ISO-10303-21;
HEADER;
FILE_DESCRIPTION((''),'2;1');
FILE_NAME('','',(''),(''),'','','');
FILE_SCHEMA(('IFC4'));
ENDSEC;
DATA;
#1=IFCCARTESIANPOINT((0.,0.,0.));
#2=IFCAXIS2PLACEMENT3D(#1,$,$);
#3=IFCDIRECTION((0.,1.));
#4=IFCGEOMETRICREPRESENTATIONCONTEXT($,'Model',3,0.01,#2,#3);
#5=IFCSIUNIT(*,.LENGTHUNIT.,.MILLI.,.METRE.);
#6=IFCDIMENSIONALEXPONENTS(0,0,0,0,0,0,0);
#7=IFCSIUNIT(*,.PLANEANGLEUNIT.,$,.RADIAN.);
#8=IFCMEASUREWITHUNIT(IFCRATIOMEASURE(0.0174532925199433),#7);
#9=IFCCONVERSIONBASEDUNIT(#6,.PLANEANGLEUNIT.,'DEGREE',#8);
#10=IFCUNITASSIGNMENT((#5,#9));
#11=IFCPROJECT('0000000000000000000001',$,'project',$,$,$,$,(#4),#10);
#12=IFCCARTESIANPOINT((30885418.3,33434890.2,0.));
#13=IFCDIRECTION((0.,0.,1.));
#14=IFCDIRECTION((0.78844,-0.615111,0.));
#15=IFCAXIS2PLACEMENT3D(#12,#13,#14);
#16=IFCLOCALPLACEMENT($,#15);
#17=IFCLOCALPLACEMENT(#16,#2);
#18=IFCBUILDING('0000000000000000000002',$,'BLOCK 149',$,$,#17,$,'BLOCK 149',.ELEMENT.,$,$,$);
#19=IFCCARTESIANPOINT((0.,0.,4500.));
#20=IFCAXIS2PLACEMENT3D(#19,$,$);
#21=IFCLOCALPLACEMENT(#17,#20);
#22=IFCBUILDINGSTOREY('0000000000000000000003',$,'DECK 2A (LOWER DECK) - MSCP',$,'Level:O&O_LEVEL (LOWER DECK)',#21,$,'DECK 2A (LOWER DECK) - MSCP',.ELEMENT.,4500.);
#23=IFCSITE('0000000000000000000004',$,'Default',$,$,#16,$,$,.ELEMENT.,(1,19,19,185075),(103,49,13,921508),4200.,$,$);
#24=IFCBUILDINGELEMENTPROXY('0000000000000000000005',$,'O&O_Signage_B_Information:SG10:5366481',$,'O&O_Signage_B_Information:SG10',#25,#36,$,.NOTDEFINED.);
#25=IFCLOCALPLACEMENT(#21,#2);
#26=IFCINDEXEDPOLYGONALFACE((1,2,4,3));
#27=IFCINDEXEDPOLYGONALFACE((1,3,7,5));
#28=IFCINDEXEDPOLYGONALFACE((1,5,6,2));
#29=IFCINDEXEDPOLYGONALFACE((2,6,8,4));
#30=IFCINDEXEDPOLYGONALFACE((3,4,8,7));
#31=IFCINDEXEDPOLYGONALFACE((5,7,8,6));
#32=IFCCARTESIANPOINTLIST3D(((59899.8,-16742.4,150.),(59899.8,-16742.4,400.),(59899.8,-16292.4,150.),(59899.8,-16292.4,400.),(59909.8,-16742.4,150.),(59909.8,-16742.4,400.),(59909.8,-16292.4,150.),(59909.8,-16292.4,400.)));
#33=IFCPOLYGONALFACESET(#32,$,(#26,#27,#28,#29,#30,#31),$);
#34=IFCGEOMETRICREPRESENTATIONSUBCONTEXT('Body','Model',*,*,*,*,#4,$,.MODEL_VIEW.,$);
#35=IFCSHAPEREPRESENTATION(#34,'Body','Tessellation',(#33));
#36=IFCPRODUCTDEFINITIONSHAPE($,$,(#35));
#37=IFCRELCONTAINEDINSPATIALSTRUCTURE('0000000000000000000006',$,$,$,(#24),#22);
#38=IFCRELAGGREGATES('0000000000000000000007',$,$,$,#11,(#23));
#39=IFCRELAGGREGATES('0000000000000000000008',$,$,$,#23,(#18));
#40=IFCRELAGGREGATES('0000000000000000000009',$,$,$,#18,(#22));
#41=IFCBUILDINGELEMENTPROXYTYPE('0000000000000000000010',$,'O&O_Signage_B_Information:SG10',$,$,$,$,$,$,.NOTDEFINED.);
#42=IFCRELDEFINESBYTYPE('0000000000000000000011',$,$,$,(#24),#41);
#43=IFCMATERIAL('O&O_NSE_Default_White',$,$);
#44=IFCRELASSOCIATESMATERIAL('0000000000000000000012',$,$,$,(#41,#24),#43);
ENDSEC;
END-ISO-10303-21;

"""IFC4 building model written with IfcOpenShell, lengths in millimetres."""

from ifc_helpers import new_model, entity, si_unit, converted_unit, direction, frame, origin, place, context, subcontext, project, spatial, indexed_curve, outline, extrude, source, transform, mapped, material, type_object, type_shapes, element, save


model = new_model("IFC4")

# Units and contexts
model_context = context("Model", 3, precision=0.01, world=origin(), true_north=direction((0.0, 1.0)))
body_context = subcontext(model_context, "Body", "Model", "MODEL_VIEW")
ifc_project = project(units=[si_unit("LENGTHUNIT", "METRE", prefix="MILLI"), converted_unit("PLANEANGLEUNIT", "DEGREE", entity("IfcRatioMeasure", 0.0174532925199433), si_unit("PLANEANGLEUNIT", "RADIAN"), dimensions=[0, 0, 0, 0, 0, 0, 0])], contexts=[model_context])

# Site, building, storey
site_placement = place(None, frame((30885418.3, 33434890.2, 0.0), z_axis=(0.0, 0.0, 1.0), x_axis=(0.78844, -0.615111, 0.0)))
site = spatial("IfcSite", under=ifc_project, at=site_placement, Name="Default", CompositionType="ELEMENT", RefLatitude=(1, 19, 19, 185075), RefLongitude=(103, 49, 13, 921508), RefElevation=4200.0)
building_placement = place(site_placement, origin())
building = spatial("IfcBuilding", under=site, at=building_placement, Name="BLOCK 149", LongName="BLOCK 149", CompositionType="ELEMENT")
storey_placement = place(building_placement, frame((0.0, 0.0, 4500.0)))
storey = spatial("IfcBuildingStorey", under=building, at=storey_placement, Name="DECK 2A (LOWER DECK) - MSCP", ObjectType="Level:O&O_LEVEL (LOWER DECK)", LongName="DECK 2A (LOWER DECK) - MSCP", CompositionType="ELEMENT", Elevation=4500.0)

# Building element proxy
ifc_material_1 = material(Name="O&O_NSE_Default_White")
building_element_proxy_type_1 = type_object("IfcBuildingElementProxyType", Name="O&O_Signage_B_Information:SG10", PredefinedType="NOTDEFINED", material=ifc_material_1)
shared_shape_1 = source(origin(), body_context, "Body", "SweptSolid", [
    extrude(outline(indexed_curve([(-5.0, -225.0), (5.0, -225.0), (5.0, 225.0), (-5.0, 225.0), (-5.0, -225.0)], self_intersect=False)), frame((0.0, 5.0, 150.0), z_axis=(0.0, 0.0, 1.0), x_axis=(0.0, 1.0, 0.0)), (0.0, 0.0, 1.0), 250.0),
])
type_shapes(building_element_proxy_type_1, [shared_shape_1])
for number, where, z_axis, x_axis, name in (
    (1, (59899.8, -16517.4, 0.0), (0.0, 0.0, 1.0), (0.000001, -1.0, 0.0), "O&O_Signage_B_Information:SG10:5366481"),
):
    element("IfcBuildingElementProxy", number, at=place(storey_placement, frame(where, z_axis=z_axis, x_axis=x_axis)), inside=storey, type_object=building_element_proxy_type_1, material=ifc_material_1, Name=name, ObjectType="O&O_Signage_B_Information:SG10", PredefinedType="NOTDEFINED", context=body_context, shape_type="MappedRepresentation", body=[
        mapped(shared_shape_1, transform((0.0, 0.0, 0.0), scale=1.0)),
    ])

save(model, "model.ifc")
